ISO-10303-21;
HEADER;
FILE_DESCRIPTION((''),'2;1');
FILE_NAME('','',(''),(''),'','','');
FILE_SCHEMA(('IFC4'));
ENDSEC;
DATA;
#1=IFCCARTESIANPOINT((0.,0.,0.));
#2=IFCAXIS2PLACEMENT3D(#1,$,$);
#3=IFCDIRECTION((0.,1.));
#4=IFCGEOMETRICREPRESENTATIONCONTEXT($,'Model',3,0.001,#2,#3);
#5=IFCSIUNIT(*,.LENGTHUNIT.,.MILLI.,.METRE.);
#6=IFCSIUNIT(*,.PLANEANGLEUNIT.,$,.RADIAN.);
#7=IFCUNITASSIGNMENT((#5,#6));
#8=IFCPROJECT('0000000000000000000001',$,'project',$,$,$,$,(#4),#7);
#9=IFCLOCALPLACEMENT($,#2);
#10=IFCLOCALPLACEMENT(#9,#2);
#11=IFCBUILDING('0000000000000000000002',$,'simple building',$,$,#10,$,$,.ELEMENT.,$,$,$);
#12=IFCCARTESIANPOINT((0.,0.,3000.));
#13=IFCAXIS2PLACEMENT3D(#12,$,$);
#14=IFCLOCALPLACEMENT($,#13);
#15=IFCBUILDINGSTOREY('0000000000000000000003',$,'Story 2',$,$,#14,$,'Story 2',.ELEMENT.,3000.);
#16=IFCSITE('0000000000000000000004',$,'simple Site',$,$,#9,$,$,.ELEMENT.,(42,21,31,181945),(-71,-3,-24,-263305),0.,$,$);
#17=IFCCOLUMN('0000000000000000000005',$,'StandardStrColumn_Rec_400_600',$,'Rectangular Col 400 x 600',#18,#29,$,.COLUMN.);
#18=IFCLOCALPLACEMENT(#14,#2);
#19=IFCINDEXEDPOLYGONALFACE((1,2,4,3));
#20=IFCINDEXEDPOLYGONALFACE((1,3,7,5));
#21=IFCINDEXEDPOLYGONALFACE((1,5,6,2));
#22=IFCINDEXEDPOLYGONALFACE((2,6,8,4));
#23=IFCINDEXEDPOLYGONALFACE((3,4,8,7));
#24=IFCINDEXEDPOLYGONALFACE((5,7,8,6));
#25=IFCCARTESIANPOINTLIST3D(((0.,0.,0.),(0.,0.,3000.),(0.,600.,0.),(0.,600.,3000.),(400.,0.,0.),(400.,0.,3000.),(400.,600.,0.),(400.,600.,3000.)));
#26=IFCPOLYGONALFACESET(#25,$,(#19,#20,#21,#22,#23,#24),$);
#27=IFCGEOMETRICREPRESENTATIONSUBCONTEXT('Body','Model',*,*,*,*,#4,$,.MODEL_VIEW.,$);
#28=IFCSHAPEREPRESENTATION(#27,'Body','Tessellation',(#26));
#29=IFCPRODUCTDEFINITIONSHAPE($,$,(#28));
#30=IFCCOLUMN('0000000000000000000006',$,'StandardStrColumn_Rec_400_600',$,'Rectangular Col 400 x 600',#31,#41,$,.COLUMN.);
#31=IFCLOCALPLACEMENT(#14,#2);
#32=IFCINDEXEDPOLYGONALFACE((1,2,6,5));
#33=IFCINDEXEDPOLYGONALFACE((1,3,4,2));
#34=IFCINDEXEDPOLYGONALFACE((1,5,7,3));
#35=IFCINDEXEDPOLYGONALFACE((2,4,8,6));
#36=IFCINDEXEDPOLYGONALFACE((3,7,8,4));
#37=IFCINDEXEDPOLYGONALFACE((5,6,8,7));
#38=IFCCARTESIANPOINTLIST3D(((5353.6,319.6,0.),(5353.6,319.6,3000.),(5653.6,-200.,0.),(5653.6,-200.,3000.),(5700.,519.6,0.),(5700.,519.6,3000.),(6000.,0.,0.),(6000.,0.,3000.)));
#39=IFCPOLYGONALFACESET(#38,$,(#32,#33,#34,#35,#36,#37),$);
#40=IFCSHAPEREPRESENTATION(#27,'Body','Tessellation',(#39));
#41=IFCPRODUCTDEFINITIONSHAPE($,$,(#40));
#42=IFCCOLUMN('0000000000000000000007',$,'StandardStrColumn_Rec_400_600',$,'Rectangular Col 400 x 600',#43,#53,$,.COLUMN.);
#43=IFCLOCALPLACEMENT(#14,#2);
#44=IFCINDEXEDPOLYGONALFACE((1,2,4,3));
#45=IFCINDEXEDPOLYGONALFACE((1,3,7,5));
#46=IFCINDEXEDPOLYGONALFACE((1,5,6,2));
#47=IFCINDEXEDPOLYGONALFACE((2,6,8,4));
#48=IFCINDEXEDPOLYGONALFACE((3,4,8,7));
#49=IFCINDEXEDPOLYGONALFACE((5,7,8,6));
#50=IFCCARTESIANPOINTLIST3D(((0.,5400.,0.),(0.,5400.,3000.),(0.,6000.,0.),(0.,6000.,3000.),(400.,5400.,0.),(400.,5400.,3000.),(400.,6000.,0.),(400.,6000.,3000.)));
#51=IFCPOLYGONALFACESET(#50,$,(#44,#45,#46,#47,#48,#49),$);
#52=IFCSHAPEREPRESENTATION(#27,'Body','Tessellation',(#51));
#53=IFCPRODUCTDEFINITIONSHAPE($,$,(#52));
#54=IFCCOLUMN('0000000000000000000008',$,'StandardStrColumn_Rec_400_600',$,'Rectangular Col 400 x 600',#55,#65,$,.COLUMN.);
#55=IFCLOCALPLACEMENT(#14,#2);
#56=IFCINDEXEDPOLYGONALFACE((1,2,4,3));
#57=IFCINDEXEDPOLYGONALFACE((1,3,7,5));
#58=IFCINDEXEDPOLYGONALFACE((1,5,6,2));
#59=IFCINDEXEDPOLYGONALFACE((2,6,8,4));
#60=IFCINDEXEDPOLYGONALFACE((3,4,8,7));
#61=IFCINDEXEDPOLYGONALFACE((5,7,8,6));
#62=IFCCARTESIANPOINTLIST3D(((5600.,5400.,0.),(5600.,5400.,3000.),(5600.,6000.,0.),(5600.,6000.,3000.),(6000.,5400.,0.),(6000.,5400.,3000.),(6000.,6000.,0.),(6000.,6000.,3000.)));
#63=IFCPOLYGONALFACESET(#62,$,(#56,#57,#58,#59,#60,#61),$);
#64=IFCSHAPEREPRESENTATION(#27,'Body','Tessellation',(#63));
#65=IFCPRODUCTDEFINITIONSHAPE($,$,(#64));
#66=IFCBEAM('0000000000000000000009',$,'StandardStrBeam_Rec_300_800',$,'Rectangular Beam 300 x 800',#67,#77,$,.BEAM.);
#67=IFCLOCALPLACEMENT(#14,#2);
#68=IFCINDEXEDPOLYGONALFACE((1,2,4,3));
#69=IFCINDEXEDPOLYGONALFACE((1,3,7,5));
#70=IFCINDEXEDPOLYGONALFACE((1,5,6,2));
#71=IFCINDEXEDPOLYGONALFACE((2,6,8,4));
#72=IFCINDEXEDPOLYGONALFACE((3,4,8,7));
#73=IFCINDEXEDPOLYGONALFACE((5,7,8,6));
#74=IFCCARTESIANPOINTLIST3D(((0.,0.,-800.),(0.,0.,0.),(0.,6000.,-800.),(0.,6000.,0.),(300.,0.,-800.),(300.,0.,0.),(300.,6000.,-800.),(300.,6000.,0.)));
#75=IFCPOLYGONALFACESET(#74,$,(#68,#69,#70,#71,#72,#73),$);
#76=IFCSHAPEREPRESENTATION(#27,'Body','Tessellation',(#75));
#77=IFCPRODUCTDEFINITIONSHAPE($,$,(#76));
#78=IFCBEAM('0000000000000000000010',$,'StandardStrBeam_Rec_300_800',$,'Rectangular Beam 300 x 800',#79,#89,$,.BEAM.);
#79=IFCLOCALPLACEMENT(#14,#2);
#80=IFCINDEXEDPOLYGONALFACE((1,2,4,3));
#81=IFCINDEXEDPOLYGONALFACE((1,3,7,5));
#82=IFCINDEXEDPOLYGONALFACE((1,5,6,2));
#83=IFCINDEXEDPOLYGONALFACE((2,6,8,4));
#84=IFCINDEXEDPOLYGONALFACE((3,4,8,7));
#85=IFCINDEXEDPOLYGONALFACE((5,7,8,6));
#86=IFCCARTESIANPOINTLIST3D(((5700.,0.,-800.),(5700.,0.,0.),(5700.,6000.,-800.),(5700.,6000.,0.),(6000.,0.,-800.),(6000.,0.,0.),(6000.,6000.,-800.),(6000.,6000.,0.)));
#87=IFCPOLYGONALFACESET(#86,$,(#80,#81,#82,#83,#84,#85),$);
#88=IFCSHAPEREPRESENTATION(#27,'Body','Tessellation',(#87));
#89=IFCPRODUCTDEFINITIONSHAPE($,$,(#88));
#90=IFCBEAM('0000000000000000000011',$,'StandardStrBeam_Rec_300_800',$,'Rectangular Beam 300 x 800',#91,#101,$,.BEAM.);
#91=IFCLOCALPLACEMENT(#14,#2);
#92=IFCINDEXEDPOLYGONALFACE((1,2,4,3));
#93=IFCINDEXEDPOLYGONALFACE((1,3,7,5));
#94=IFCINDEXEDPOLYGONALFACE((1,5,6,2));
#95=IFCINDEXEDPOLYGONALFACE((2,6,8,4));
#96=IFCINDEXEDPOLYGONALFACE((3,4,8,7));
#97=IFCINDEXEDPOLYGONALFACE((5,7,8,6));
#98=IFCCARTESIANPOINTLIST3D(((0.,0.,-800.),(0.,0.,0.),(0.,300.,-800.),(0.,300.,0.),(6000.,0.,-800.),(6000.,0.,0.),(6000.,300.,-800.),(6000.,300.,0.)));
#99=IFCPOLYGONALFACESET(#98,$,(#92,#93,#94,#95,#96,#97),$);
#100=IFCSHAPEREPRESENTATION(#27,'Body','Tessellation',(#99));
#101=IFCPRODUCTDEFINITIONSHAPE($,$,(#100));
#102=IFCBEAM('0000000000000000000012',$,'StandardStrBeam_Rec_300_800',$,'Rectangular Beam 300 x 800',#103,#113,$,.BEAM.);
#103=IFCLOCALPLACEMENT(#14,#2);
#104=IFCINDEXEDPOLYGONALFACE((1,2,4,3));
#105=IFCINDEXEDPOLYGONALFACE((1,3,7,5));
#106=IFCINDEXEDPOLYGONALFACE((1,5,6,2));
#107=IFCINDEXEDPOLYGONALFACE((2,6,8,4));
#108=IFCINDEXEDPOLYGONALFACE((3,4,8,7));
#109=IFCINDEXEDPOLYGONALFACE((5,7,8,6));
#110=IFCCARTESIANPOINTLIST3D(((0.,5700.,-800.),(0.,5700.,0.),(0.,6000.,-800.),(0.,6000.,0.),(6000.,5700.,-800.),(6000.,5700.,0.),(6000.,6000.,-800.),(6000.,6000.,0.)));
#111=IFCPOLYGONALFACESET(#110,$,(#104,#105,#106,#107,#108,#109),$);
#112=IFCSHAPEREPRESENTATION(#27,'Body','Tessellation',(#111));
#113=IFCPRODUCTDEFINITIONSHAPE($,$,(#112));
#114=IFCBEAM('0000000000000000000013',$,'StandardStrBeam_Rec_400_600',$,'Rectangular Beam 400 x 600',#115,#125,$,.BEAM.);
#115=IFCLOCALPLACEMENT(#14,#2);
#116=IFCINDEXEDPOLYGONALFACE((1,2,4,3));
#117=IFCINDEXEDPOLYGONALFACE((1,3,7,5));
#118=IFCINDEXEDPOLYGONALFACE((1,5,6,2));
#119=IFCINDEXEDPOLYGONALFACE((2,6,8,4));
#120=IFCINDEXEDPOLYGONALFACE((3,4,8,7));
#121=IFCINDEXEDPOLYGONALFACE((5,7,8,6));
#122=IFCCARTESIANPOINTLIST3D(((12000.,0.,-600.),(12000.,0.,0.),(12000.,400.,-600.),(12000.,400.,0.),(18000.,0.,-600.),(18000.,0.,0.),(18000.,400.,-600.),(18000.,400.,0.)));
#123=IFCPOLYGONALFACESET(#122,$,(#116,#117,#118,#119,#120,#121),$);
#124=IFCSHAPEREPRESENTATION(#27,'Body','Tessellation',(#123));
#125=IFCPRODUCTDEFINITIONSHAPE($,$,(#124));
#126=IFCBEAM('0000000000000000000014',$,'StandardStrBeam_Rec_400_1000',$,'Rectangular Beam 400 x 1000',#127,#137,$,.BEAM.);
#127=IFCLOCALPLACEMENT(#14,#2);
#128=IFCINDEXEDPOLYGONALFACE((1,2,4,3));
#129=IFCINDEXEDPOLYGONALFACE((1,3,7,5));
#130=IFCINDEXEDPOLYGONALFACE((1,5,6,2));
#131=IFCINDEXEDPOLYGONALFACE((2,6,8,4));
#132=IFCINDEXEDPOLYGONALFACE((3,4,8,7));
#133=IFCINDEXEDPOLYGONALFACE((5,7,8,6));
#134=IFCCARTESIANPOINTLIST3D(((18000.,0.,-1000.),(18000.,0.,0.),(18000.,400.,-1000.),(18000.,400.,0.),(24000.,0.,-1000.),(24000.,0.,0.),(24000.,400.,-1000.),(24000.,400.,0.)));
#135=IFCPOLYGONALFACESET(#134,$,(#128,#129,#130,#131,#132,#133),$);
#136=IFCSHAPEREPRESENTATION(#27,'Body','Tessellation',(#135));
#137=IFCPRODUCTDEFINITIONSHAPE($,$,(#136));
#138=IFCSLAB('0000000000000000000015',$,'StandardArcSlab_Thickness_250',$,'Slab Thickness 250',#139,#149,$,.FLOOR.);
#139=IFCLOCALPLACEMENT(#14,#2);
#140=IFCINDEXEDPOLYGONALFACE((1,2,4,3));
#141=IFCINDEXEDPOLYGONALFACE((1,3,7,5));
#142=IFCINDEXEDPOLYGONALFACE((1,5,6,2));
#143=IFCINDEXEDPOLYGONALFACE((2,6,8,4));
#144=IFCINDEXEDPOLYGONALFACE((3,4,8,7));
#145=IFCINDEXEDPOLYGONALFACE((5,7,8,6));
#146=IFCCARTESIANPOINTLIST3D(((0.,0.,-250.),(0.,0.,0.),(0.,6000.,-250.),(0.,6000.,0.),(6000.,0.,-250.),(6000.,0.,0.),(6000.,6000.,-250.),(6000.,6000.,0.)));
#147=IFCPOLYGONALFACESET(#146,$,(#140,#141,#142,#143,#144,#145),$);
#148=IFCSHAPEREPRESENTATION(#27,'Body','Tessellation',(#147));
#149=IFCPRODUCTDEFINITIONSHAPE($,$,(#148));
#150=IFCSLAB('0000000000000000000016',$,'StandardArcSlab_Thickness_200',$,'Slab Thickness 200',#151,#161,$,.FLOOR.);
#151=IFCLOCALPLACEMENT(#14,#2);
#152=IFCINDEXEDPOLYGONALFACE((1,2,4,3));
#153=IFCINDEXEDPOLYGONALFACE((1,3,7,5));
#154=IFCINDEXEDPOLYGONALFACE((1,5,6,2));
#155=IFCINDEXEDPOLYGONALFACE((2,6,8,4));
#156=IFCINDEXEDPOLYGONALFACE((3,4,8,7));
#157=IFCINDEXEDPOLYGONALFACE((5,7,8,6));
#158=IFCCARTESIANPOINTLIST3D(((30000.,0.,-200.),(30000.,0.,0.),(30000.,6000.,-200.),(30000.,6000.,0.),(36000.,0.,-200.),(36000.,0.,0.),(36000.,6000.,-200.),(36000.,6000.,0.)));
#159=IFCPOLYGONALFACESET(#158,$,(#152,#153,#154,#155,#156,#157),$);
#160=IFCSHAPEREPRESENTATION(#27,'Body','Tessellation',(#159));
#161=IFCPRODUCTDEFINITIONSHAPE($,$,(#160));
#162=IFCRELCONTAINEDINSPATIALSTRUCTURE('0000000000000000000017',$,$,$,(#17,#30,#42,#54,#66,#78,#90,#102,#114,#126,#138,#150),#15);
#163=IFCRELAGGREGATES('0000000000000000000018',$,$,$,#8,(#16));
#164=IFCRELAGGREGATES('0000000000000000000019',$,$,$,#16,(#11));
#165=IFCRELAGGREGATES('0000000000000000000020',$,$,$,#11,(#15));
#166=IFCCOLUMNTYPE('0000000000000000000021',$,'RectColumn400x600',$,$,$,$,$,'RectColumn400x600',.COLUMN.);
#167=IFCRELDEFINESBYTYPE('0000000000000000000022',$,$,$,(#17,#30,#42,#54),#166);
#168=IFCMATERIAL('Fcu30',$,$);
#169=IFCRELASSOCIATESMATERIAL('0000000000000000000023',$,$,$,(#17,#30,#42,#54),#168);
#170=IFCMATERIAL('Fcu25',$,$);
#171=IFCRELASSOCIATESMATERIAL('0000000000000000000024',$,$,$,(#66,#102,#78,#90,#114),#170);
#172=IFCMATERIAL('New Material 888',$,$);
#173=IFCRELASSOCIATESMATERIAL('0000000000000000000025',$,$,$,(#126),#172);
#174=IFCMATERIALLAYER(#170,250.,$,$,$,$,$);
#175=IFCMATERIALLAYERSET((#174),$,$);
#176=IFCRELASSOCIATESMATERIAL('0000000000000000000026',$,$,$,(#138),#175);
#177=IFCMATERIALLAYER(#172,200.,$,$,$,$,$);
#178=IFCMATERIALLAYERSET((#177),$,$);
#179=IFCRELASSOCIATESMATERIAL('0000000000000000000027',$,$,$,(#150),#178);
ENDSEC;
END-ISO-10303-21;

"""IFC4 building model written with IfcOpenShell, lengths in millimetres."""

from ifc_helpers import new_model, si_unit, direction, frame, origin, origin_with_axes, origin_2d_with_axis, place, context, subcontext, project, spatial, polyline, rectangle, outline, extrude, material, layer, layer_set, layer_usage, material_profile, profile_set, profile_usage, type_object, element, save


model = new_model("IFC4")

# Units and contexts
model_context = context("Model", 3, precision=0.001, world=origin(), true_north=direction((0.0, 1.0)))
body_context = subcontext(model_context, "Body", "Model", "MODEL_VIEW")
ifc_project = project(units=[si_unit("LENGTHUNIT", "METRE", prefix="MILLI"), si_unit("PLANEANGLEUNIT", "RADIAN")], contexts=[model_context])

# Site, building, storey
site_placement = place(None, origin())
site = spatial("IfcSite", under=ifc_project, at=site_placement, Name="simple Site", CompositionType="ELEMENT", RefLatitude=(42, 21, 31, 181945), RefLongitude=(-71, -3, -24, -263305), RefElevation=0.0)
building_placement = place(site_placement, origin())
building = spatial("IfcBuilding", under=site, at=building_placement, Name="simple building", CompositionType="ELEMENT")
storey_placement = place(None, frame((0.0, 0.0, 3000.0)))
storey = spatial("IfcBuildingStorey", under=building, at=storey_placement, Name="Story 2", LongName="Story 2", CompositionType="ELEMENT", Elevation=3000.0)

# Columns
ifc_material_1 = material(Name="Fcu30")
ifc_material_profile_1 = material_profile(ifc_material_1, rectangle(XDim=400.0, YDim=600.0, at=origin_2d_with_axis()))
ifc_profile_set_1 = profile_set([ifc_material_profile_1])
ifc_profile_usage_1 = profile_usage(ifc_profile_set_1, cardinal=7)
column_type = type_object("IfcColumnType", Name="RectColumn400x600", ElementType="RectColumn400x600", PredefinedType="COLUMN")
column_1_placement = place(None, frame((200.0, 300.0, 3000.0), z_axis=(0.0, 0.0, 1.0), x_axis=(1.0, 0.0, 0.0)))
element("IfcColumn", 1, at=column_1_placement, inside=storey, type_object=column_type, material=ifc_profile_usage_1, Name="StandardStrColumn_Rec_400_600", ObjectType="Rectangular Col 400 x 600", PredefinedType="COLUMN", context=body_context, shape_type="SweptSolid", body=[
    extrude(rectangle(XDim=400.0, YDim=600.0, at=origin_2d_with_axis()), origin_with_axes(), (0.0, 0.0, 1.0), 3000.0),
])
ifc_profile_usage_2 = profile_usage(ifc_profile_set_1, cardinal=9)
column_2_placement = place(None, frame((5676.8, 159.8, 3000.0), z_axis=(0.0, 0.0, 1.0), x_axis=(0.866025, 0.5, 0.0)))
element("IfcColumn", 2, at=column_2_placement, inside=storey, type_object=column_type, material=ifc_profile_usage_2, Name="StandardStrColumn_Rec_400_600", ObjectType="Rectangular Col 400 x 600", PredefinedType="COLUMN", context=body_context, shape_type="SweptSolid", body=[
    extrude(rectangle(XDim=400.0, YDim=600.0, at=origin_2d_with_axis()), origin_with_axes(), (0.0, 0.0, 1.0), 3000.0),
])
ifc_profile_usage_3 = profile_usage(ifc_profile_set_1, cardinal=1)
column_3_placement = place(None, frame((200.0, 5700.0, 3000.0), z_axis=(0.0, 0.0, 1.0), x_axis=(1.0, 0.0, 0.0)))
element("IfcColumn", 3, at=column_3_placement, inside=storey, type_object=column_type, material=ifc_profile_usage_3, Name="StandardStrColumn_Rec_400_600", ObjectType="Rectangular Col 400 x 600", PredefinedType="COLUMN", context=body_context, shape_type="SweptSolid", body=[
    extrude(rectangle(XDim=400.0, YDim=600.0, at=origin_2d_with_axis()), origin_with_axes(), (0.0, 0.0, 1.0), 3000.0),
])
ifc_profile_usage_4 = profile_usage(ifc_profile_set_1, cardinal=3)
column_4_placement = place(None, frame((5800.0, 5700.0, 3000.0), z_axis=(0.0, 0.0, 1.0), x_axis=(1.0, 0.0, 0.0)))
element("IfcColumn", 4, at=column_4_placement, inside=storey, type_object=column_type, material=ifc_profile_usage_4, Name="StandardStrColumn_Rec_400_600", ObjectType="Rectangular Col 400 x 600", PredefinedType="COLUMN", context=body_context, shape_type="SweptSolid", body=[
    extrude(rectangle(XDim=400.0, YDim=600.0, at=origin_2d_with_axis()), origin_with_axes(), (0.0, 0.0, 1.0), 3000.0),
])

# Beams
ifc_material_2 = material(Name="Fcu25")
ifc_material_profile_2 = material_profile(ifc_material_2, rectangle(XDim=300.0, YDim=800.0, at=origin_2d_with_axis()))
ifc_profile_set_2 = profile_set([ifc_material_profile_2])
ifc_profile_usage_5 = profile_usage(ifc_profile_set_2, cardinal=7)
beam_1_placement = place(None, frame((150.0, 0.0, 2600.0), z_axis=(0.0, 1.0, 0.0), x_axis=(1.0, 0.0, 0.0)))
element("IfcBeam", 5, at=beam_1_placement, inside=storey, material=ifc_profile_usage_5, Name="StandardStrBeam_Rec_300_800", ObjectType="Rectangular Beam 300 x 800", PredefinedType="BEAM", context=body_context, shape_type="SweptSolid", body=[
    extrude(rectangle(XDim=300.0, YDim=800.0, at=origin_2d_with_axis()), origin_with_axes(), (0.0, 0.0, 1.0), 6000.0),
])
ifc_profile_usage_6 = profile_usage(ifc_profile_set_2, cardinal=9)
for number, where, z_axis, x_axis, name in (
    (6, (5850.0, 0.0, 2600.0), (0.0, 1.0, 0.0), (1.0, 0.0, 0.0), "StandardStrBeam_Rec_300_800"),
    (7, (0.0, 150.0, 2600.0), (1.0, 0.0, 0.0), (0.0, -1.0, 0.0), "StandardStrBeam_Rec_300_800"),
):
    element("IfcBeam", number, at=place(None, frame(where, z_axis=z_axis, x_axis=x_axis)), inside=storey, material=ifc_profile_usage_6, Name=name, ObjectType="Rectangular Beam 300 x 800", PredefinedType="BEAM", context=body_context, shape_type="SweptSolid", body=[
        extrude(rectangle(XDim=300.0, YDim=800.0, at=origin_2d_with_axis()), origin_with_axes(), (0.0, 0.0, 1.0), 6000.0),
    ])
beam_2_placement = place(None, frame((0.0, 5850.0, 2600.0), z_axis=(1.0, 0.0, 0.0), x_axis=(0.0, -1.0, 0.0)))
element("IfcBeam", 8, at=beam_2_placement, inside=storey, material=ifc_profile_usage_5, Name="StandardStrBeam_Rec_300_800", ObjectType="Rectangular Beam 300 x 800", PredefinedType="BEAM", context=body_context, shape_type="SweptSolid", body=[
    extrude(rectangle(XDim=300.0, YDim=800.0, at=origin_2d_with_axis()), origin_with_axes(), (0.0, 0.0, 1.0), 6000.0),
])
ifc_material_profile_3 = material_profile(ifc_material_2, rectangle(XDim=400.0, YDim=600.0, at=origin_2d_with_axis()))
ifc_profile_set_3 = profile_set([ifc_material_profile_3])
ifc_profile_usage_7 = profile_usage(ifc_profile_set_3, cardinal=9)
beam_3_placement = place(None, frame((12000.0, 200.0, 2700.0), z_axis=(1.0, 0.0, 0.0), x_axis=(0.0, -1.0, 0.0)))
element("IfcBeam", 9, at=beam_3_placement, inside=storey, material=ifc_profile_usage_7, Name="StandardStrBeam_Rec_400_600", ObjectType="Rectangular Beam 400 x 600", PredefinedType="BEAM", context=body_context, shape_type="SweptSolid", body=[
    extrude(rectangle(XDim=400.0, YDim=600.0, at=origin_2d_with_axis()), origin_with_axes(), (0.0, 0.0, 1.0), 6000.0),
])
ifc_material_3 = material(Name="New Material 888")
ifc_material_profile_4 = material_profile(ifc_material_3, rectangle(XDim=400.0, YDim=1000.0, at=origin_2d_with_axis()))
ifc_profile_set_4 = profile_set([ifc_material_profile_4])
ifc_profile_usage_8 = profile_usage(ifc_profile_set_4, cardinal=9)
beam_4_placement = place(None, frame((18000.0, 200.0, 2500.0), z_axis=(1.0, 0.0, 0.0), x_axis=(0.0, -1.0, 0.0)))
element("IfcBeam", 10, at=beam_4_placement, inside=storey, material=ifc_profile_usage_8, Name="StandardStrBeam_Rec_400_1000", ObjectType="Rectangular Beam 400 x 1000", PredefinedType="BEAM", context=body_context, shape_type="SweptSolid", body=[
    extrude(rectangle(XDim=400.0, YDim=1000.0, at=origin_2d_with_axis()), origin_with_axes(), (0.0, 0.0, 1.0), 6000.0),
])

# Slabs
ifc_layer_1 = layer(ifc_material_2, 250.0)
ifc_layer_set_1 = layer_set([ifc_layer_1])
ifc_layer_usage_1 = layer_usage(ifc_layer_set_1, "AXIS3", "POSITIVE", -250.0)
slab_1_placement = place(None, frame((0.0, 0.0, 2750.0), z_axis=(0.0, 0.0, 1.0), x_axis=(1.0, 0.0, 0.0)))
element("IfcSlab", 11, at=slab_1_placement, inside=storey, material=ifc_layer_usage_1, Name="StandardArcSlab_Thickness_250", ObjectType="Slab Thickness 250", PredefinedType="FLOOR", context=body_context, shape_type="SweptSolid", body=[
    extrude(outline(polyline([(0.0, 0.0), (6000.0, 0.0), (6000.0, 6000.0), (0.0, 6000.0), (0.0, 0.0)])), origin_with_axes(), (0.0, 0.0, 1.0), 250.0),
])
ifc_layer_2 = layer(ifc_material_3, 200.0)
ifc_layer_set_2 = layer_set([ifc_layer_2])
ifc_layer_usage_2 = layer_usage(ifc_layer_set_2, "AXIS3", "POSITIVE", -200.0)
slab_2_placement = place(None, frame((30000.0, 0.0, 2800.0), z_axis=(0.0, 0.0, 1.0), x_axis=(1.0, 0.0, 0.0)))
element("IfcSlab", 12, at=slab_2_placement, inside=storey, material=ifc_layer_usage_2, Name="StandardArcSlab_Thickness_200", ObjectType="Slab Thickness 200", PredefinedType="FLOOR", context=body_context, shape_type="SweptSolid", body=[
    extrude(outline(polyline([(0.0, 0.0), (6000.0, 0.0), (6000.0, 6000.0), (0.0, 6000.0), (0.0, 0.0)])), origin_with_axes(), (0.0, 0.0, 1.0), 200.0),
])

save(model, "model.ifc")
